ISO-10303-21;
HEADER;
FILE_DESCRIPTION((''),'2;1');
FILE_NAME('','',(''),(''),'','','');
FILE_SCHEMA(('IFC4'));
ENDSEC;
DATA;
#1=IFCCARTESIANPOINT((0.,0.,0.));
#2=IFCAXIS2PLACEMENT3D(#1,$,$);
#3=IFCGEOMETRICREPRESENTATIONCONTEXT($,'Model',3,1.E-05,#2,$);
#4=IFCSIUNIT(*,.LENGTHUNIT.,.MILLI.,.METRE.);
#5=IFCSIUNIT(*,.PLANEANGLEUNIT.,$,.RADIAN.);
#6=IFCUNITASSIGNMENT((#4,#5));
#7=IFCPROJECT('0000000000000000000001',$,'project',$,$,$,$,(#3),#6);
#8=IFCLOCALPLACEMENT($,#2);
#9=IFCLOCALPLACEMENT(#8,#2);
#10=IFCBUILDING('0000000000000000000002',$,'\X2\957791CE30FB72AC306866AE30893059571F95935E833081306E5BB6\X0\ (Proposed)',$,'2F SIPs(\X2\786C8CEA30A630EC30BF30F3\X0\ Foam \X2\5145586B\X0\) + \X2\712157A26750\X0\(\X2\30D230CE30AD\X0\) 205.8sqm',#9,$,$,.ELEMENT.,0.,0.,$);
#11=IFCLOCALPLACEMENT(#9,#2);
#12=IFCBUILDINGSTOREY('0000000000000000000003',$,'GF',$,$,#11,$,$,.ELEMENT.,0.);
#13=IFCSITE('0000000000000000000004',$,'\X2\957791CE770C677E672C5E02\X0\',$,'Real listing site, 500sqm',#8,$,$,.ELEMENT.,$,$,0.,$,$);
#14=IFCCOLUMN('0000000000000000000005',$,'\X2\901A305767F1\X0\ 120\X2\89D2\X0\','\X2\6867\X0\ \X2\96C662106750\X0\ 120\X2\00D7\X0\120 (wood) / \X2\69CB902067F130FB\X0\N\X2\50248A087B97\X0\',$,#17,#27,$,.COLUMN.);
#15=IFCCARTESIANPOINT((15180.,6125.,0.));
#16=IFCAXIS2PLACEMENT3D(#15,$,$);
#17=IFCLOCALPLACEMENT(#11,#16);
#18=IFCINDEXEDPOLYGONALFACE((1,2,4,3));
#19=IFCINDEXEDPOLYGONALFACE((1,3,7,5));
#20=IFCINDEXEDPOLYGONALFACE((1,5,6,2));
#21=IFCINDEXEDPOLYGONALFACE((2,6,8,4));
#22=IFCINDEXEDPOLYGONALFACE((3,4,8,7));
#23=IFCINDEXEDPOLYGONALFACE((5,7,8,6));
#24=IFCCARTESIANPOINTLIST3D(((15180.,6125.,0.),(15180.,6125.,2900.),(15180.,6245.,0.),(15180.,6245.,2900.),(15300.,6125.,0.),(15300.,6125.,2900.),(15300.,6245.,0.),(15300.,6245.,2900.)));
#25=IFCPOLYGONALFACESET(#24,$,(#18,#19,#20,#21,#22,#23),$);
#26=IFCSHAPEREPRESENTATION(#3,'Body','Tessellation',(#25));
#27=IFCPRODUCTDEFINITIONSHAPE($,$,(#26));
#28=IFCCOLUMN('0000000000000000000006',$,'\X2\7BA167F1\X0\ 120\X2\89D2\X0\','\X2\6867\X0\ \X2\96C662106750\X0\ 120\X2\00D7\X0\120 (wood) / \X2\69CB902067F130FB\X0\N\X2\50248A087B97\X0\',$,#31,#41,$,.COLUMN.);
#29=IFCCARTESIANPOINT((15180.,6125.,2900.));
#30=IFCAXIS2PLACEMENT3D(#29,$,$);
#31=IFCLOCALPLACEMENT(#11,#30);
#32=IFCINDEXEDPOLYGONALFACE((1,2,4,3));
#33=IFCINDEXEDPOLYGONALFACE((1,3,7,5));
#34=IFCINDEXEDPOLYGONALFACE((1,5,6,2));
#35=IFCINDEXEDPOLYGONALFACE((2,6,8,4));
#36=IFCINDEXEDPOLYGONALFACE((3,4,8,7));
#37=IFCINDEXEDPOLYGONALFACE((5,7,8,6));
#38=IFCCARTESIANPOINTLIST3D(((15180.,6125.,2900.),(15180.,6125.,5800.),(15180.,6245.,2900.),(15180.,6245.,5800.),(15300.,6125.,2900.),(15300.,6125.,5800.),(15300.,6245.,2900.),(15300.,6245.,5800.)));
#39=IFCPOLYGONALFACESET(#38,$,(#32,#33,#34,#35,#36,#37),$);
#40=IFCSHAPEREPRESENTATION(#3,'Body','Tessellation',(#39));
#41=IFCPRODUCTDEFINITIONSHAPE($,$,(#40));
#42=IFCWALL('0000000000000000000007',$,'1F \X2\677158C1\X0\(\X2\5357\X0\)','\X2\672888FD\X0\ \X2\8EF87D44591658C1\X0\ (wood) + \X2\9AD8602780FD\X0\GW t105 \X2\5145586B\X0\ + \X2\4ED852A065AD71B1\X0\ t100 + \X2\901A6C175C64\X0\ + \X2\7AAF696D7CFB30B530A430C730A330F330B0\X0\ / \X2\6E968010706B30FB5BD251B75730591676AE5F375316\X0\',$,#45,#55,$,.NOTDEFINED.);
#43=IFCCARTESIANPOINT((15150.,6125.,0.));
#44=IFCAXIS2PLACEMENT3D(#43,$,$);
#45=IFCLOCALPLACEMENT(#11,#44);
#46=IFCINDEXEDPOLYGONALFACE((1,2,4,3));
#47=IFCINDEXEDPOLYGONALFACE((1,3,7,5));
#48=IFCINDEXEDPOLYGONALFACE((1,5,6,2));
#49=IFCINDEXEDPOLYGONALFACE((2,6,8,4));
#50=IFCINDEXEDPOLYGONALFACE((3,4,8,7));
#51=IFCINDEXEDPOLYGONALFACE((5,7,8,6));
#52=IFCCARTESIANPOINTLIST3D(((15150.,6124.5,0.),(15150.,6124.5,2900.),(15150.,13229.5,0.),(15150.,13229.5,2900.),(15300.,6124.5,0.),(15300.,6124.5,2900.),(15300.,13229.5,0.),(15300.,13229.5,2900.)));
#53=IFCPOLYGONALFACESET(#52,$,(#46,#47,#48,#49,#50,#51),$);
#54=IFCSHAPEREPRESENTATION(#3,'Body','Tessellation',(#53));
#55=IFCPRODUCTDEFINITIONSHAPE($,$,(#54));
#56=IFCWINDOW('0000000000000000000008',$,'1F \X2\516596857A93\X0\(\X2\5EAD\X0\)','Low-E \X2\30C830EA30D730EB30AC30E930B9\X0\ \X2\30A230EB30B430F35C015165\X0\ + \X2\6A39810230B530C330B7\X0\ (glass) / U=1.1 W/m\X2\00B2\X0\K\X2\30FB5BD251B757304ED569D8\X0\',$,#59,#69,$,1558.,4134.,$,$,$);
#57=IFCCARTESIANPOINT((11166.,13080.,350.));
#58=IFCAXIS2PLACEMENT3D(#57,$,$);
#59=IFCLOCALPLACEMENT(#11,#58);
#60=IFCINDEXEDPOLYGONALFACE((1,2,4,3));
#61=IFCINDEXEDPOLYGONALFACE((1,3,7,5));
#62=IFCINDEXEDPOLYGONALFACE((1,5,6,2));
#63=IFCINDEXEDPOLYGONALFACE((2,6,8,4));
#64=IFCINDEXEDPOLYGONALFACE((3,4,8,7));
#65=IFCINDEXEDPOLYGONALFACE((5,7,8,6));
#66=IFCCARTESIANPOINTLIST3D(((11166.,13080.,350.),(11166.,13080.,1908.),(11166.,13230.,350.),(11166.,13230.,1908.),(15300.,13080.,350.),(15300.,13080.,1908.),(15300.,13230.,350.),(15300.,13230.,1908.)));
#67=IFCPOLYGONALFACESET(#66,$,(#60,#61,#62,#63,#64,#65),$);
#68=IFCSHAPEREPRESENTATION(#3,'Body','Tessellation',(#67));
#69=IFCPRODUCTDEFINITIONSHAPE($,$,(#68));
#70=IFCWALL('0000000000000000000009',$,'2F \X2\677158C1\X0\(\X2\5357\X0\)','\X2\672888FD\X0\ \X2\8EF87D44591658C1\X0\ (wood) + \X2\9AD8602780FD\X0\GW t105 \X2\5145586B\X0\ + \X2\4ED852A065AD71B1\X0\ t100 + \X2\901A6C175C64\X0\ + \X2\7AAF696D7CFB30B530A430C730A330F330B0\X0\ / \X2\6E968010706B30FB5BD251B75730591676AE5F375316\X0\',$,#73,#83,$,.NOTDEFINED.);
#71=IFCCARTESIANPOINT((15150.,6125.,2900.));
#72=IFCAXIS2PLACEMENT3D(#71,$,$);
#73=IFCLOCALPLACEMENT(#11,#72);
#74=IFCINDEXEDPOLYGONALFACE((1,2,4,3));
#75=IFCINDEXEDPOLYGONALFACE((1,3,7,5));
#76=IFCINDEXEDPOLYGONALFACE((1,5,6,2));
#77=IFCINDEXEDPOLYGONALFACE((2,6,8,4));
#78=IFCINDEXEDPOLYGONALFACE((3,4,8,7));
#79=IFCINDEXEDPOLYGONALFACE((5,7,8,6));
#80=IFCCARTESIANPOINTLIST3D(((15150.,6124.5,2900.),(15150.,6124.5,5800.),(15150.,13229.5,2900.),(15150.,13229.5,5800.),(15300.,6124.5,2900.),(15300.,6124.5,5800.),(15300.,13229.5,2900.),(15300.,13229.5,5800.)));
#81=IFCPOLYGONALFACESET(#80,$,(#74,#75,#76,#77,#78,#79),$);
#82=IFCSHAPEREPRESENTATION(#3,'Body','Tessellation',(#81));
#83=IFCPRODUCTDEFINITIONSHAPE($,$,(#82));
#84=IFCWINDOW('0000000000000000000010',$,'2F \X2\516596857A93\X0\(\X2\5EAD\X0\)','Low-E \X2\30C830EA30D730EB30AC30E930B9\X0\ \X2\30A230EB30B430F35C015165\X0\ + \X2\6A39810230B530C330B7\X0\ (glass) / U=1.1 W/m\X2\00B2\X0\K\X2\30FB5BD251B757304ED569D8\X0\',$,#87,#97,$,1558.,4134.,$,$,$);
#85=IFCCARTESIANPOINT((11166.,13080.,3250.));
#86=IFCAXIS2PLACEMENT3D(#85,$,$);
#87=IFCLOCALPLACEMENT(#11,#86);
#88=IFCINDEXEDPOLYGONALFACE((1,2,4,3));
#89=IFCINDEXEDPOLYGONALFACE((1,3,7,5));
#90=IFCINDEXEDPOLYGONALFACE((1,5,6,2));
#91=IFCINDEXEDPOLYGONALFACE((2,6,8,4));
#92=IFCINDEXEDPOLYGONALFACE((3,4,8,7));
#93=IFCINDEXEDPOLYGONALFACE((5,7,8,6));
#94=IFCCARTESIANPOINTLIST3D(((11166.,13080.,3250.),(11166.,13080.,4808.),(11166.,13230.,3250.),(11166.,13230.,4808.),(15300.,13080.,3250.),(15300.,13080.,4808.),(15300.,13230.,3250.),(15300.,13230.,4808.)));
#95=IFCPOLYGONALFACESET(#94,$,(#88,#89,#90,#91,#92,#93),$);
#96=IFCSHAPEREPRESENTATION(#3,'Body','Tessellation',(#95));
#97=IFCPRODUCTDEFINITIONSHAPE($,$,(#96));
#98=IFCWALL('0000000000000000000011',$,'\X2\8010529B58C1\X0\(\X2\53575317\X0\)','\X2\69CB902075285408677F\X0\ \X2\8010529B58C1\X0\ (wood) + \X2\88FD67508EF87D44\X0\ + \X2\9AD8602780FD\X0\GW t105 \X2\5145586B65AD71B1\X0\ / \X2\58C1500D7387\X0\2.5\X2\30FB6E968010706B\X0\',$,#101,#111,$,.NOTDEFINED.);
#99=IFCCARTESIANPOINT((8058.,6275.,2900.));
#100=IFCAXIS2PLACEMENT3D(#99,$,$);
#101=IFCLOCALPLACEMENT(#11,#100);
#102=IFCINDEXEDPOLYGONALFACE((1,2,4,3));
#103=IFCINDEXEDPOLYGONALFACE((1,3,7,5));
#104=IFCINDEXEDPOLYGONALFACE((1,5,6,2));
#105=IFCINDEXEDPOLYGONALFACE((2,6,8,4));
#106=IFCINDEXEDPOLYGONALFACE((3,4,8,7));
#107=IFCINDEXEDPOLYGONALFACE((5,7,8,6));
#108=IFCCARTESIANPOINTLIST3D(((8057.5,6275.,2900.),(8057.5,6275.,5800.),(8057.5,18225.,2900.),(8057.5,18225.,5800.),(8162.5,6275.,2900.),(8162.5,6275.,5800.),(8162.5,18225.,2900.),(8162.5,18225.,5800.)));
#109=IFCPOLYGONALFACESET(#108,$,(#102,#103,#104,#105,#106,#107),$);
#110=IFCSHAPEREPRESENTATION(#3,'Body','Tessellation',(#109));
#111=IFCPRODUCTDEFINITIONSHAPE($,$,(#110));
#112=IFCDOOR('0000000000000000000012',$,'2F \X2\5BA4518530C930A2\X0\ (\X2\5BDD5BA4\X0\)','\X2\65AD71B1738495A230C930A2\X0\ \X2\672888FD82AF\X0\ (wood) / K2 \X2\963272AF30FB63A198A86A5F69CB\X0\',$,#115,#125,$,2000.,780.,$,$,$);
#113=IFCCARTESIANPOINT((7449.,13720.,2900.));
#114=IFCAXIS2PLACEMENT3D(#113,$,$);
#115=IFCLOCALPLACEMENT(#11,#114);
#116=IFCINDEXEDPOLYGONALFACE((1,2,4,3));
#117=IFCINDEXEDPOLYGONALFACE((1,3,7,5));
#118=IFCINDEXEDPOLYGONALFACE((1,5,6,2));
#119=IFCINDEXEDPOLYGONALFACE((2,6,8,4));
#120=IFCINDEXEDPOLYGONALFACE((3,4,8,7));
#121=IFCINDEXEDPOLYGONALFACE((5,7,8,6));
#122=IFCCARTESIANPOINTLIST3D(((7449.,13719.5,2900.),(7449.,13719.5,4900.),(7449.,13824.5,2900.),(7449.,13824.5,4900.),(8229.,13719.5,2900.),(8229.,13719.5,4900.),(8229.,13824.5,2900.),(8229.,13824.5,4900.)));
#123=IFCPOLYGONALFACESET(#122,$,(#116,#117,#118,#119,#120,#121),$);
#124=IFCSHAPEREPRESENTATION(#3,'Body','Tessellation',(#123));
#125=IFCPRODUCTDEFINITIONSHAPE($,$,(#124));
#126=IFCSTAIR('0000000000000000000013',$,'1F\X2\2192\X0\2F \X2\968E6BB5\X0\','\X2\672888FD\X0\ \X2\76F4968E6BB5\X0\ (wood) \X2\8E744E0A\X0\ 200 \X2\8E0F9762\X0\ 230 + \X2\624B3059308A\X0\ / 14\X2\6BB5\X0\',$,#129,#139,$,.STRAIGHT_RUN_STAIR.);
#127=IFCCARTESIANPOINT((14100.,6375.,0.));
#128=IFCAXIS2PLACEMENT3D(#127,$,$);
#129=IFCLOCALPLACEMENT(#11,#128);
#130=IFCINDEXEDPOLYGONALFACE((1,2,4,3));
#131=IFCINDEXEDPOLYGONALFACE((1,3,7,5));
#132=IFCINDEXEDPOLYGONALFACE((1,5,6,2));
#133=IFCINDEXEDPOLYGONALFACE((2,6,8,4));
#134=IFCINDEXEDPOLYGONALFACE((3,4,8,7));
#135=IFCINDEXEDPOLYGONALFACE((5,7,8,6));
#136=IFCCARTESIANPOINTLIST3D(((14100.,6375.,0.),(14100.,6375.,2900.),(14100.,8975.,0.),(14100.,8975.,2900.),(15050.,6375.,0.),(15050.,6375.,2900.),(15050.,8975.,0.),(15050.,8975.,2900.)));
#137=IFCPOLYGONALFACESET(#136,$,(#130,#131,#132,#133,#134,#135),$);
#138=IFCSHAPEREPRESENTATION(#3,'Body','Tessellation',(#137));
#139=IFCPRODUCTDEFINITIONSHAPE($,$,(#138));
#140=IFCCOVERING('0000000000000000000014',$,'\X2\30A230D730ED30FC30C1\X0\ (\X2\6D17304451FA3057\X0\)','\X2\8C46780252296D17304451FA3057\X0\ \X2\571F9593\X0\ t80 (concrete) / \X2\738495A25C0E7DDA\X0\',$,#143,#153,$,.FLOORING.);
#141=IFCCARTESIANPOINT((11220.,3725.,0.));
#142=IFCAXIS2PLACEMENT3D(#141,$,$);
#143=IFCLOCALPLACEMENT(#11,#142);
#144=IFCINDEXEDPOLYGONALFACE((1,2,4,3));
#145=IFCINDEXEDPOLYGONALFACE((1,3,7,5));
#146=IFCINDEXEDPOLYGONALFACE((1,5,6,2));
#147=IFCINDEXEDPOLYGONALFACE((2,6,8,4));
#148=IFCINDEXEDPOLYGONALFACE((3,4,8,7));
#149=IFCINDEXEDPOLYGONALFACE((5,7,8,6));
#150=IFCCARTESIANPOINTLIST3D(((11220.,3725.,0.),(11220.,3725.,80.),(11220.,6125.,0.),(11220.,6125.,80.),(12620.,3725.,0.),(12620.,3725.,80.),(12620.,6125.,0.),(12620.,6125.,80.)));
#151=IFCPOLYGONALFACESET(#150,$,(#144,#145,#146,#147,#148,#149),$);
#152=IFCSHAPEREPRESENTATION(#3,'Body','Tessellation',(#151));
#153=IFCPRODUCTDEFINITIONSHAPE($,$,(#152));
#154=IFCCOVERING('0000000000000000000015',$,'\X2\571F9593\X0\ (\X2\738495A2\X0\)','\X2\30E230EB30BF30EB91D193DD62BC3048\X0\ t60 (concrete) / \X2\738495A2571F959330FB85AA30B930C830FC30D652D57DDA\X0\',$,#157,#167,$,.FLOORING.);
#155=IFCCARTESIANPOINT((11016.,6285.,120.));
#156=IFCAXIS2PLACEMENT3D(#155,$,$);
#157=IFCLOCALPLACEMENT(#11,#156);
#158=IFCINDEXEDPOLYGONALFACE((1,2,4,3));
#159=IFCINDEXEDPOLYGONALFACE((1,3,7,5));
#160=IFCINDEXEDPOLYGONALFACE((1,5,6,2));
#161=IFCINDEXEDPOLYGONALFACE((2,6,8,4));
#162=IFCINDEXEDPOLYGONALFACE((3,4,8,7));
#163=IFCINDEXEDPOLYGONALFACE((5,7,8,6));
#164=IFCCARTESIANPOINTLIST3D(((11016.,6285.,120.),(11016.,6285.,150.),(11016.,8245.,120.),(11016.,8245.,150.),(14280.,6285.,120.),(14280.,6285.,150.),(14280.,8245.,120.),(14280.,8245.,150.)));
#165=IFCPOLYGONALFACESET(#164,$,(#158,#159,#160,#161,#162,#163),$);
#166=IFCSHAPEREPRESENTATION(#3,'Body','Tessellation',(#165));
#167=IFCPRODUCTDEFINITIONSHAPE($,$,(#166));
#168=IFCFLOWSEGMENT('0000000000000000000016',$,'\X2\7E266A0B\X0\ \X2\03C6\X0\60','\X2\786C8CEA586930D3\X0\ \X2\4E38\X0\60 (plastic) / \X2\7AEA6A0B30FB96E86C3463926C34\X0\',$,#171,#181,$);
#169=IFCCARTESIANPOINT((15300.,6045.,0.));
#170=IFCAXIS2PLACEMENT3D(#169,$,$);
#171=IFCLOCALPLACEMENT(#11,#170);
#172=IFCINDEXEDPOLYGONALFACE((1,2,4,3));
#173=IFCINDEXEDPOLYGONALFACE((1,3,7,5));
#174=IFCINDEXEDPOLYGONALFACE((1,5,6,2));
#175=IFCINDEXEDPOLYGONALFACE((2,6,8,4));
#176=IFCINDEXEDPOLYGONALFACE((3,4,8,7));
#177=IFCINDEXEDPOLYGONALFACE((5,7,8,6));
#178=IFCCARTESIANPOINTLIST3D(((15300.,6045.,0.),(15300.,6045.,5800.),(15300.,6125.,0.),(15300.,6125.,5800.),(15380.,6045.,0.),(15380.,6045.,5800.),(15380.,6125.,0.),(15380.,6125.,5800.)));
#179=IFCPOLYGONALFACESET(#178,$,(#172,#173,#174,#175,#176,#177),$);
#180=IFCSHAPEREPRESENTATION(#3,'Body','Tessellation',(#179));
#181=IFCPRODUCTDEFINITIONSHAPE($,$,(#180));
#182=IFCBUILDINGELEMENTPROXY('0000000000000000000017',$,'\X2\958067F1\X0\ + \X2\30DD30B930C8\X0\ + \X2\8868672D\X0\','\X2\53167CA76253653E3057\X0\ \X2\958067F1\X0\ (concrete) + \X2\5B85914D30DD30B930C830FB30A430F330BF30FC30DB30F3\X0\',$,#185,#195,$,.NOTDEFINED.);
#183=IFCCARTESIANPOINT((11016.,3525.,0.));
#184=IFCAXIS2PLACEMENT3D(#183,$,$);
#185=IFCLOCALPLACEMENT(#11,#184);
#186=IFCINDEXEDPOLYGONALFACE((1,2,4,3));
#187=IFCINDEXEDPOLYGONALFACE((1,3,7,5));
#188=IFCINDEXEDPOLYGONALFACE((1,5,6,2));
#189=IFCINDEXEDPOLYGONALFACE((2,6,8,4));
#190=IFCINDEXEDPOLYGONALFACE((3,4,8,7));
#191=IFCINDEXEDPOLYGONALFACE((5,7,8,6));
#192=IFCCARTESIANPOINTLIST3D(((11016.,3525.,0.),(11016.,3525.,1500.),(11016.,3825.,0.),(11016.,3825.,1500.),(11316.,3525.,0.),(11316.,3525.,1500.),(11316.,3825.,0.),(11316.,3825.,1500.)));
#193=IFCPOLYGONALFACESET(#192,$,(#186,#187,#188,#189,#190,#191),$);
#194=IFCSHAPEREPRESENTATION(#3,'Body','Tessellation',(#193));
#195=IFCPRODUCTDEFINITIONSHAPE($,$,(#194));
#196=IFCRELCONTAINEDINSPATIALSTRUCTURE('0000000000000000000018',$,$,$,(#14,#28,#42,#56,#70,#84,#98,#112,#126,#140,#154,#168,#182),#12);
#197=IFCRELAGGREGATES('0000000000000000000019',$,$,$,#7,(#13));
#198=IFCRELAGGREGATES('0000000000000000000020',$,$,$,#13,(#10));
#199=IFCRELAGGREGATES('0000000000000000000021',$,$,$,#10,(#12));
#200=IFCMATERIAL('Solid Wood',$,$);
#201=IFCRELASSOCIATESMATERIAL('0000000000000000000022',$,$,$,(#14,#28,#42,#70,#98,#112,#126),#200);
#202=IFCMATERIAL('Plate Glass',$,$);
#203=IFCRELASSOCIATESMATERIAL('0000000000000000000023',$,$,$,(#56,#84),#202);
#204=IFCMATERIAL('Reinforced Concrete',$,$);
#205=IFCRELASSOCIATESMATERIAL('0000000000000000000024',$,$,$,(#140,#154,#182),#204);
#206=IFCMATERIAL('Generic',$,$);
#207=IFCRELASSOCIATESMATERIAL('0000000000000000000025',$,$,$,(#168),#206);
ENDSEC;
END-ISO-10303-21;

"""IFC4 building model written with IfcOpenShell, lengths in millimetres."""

from ifc_helpers import new_model, si_unit, frame, frame_2d, origin, place, context, project, spatial, rectangle, extrude, material, element, fill, save


model = new_model("IFC4")

# Units and contexts
model_context = context("Model", 3, precision=1e-05, world=origin())
ifc_project = project(units=[si_unit("LENGTHUNIT", "METRE", prefix="MILLI"), si_unit("PLANEANGLEUNIT", "RADIAN")], contexts=[model_context])

# Site, building, storey
site_placement = place(None, origin())
site = spatial("IfcSite", under=ifc_project, at=site_placement, Name="長野県松本市", ObjectType="Real listing site, 500sqm", CompositionType="ELEMENT", RefElevation=0.0)
building_placement = place(site_placement, origin())
building = spatial("IfcBuilding", under=site, at=building_placement, Name="長野・犬と暮らす土間広めの家 (Proposed)", ObjectType="2F SIPs(硬質ウレタン Foam 充填) + 無垢材(ヒノキ) 205.8sqm", CompositionType="ELEMENT", ElevationOfRefHeight=0.0, ElevationOfTerrain=0.0)
storey_placement = place(building_placement, origin())
storey = spatial("IfcBuildingStorey", under=building, at=storey_placement, Name="GF", CompositionType="ELEMENT", Elevation=0.0)

# Columns
ifc_material_1 = material(Name="Solid Wood")
column_1_placement = place(storey_placement, frame((15180.0, 6125.0, 0.0)))
element("IfcColumn", 1, at=column_1_placement, inside=storey, material=ifc_material_1, Name="通し柱 120角", Description="桧 集成材 120×120 (wood) / 構造柱・N値計算", PredefinedType="COLUMN", context=model_context, shape_type="SweptSolid", body=[
    extrude(rectangle(XDim=120.0, YDim=120.0, at=frame_2d((60.0, 60.0))), frame((15180.0, 6125.0, 0.0)), (0.0, 0.0, 1.0), 2900.0),
])
column_2_placement = place(storey_placement, frame((15180.0, 6125.0, 2900.0)))
element("IfcColumn", 2, at=column_2_placement, inside=storey, material=ifc_material_1, Name="管柱 120角", Description="桧 集成材 120×120 (wood) / 構造柱・N値計算", PredefinedType="COLUMN", context=model_context, shape_type="SweptSolid", body=[
    extrude(rectangle(XDim=120.0, YDim=120.0, at=frame_2d((60.0, 60.0))), frame((15180.0, 6125.0, 2900.0)), (0.0, 0.0, 1.0), 2900.0),
])

# Wall, opening, window
wall_1_placement = place(storey_placement, frame((15150.0, 6125.0, 0.0)))
wall_1 = element("IfcWall", 3, at=wall_1_placement, inside=storey, material=ifc_material_1, Name="1F 東壁(南)", Description="木製 軸組外壁 (wood) + 高性能GW t105 充填 + 付加断熱 t100 + 通気層 + 窯業系サイディング / 準耐火・寒冷地外皮強化", PredefinedType="NOTDEFINED", context=model_context, shape_type="SweptSolid", body=[
    extrude(rectangle(XDim=150.0, YDim=7105.0, at=frame_2d((75.0, 3552.0))), frame((15150.0, 6125.0, 0.0)), (0.0, 0.0, 1.0), 2900.0),
])
opening_1_placement = place(storey_placement, frame((11166.0, 13080.0, 350.0)))
opening_1 = element("IfcOpeningElement", 4, at=opening_1_placement, cuts=wall_1, PredefinedType="NOTDEFINED", context=model_context, shape_type="SweptSolid", body=[
    extrude(rectangle(XDim=4134.0, YDim=150.0, at=frame_2d((2067.0, 75.0))), frame((11166.0, 13080.0, 350.0)), (0.0, 0.0, 1.0), 1558.0),
])
ifc_material_2 = material(Name="Plate Glass")
window_1_placement = place(storey_placement, frame((11166.0, 13080.0, 350.0)))
window_1 = element("IfcWindow", 5, at=window_1_placement, inside=storey, material=ifc_material_2, Name="1F 入隅窓(庭)", Description="Low-E トリプルガラス アルゴン封入 + 樹脂サッシ (glass) / U=1.1 W/m²K・寒冷地仕様", OverallHeight=1558.0, OverallWidth=4134.0, context=model_context, shape_type="SweptSolid", body=[
    extrude(rectangle(XDim=4134.0, YDim=150.0, at=frame_2d((2067.0, 75.0))), frame((11166.0, 13080.0, 350.0)), (0.0, 0.0, 1.0), 1558.0),
])
fill(opening_1, window_1)

# Wall, opening, window
wall_2_placement = place(storey_placement, frame((15150.0, 6125.0, 2900.0)))
wall_2 = element("IfcWall", 6, at=wall_2_placement, inside=storey, material=ifc_material_1, Name="2F 東壁(南)", Description="木製 軸組外壁 (wood) + 高性能GW t105 充填 + 付加断熱 t100 + 通気層 + 窯業系サイディング / 準耐火・寒冷地外皮強化", PredefinedType="NOTDEFINED", context=model_context, shape_type="SweptSolid", body=[
    extrude(rectangle(XDim=150.0, YDim=7105.0, at=frame_2d((75.0, 3552.0))), frame((15150.0, 6125.0, 2900.0)), (0.0, 0.0, 1.0), 2900.0),
])
opening_2_placement = place(storey_placement, frame((11166.0, 13080.0, 3250.0)))
opening_2 = element("IfcOpeningElement", 7, at=opening_2_placement, cuts=wall_2, PredefinedType="NOTDEFINED", context=model_context, shape_type="SweptSolid", body=[
    extrude(rectangle(XDim=4134.0, YDim=150.0, at=frame_2d((2067.0, 75.0))), frame((11166.0, 13080.0, 3250.0)), (0.0, 0.0, 1.0), 1558.0),
])
window_2_placement = place(storey_placement, frame((11166.0, 13080.0, 3250.0)))
window_2 = element("IfcWindow", 8, at=window_2_placement, inside=storey, material=ifc_material_2, Name="2F 入隅窓(庭)", Description="Low-E トリプルガラス アルゴン封入 + 樹脂サッシ (glass) / U=1.1 W/m²K・寒冷地仕様", OverallHeight=1558.0, OverallWidth=4134.0, context=model_context, shape_type="SweptSolid", body=[
    extrude(rectangle(XDim=4134.0, YDim=150.0, at=frame_2d((2067.0, 75.0))), frame((11166.0, 13080.0, 3250.0)), (0.0, 0.0, 1.0), 1558.0),
])
fill(opening_2, window_2)

# Wall, opening, door
wall_3_placement = place(storey_placement, frame((8058.0, 6275.0, 2900.0)))
wall_3 = element("IfcWall", 9, at=wall_3_placement, inside=storey, material=ifc_material_1, Name="耐力壁(南北)", Description="構造用合板 耐力壁 (wood) + 製材軸組 + 高性能GW t105 充填断熱 / 壁倍率2.5・準耐火", PredefinedType="NOTDEFINED", context=model_context, shape_type="SweptSolid", body=[
    extrude(rectangle(XDim=105.0, YDim=11950.0, at=frame_2d((52.0, 5975.0))), frame((8058.0, 6275.0, 2900.0)), (0.0, 0.0, 1.0), 2900.0),
])
opening_3_placement = place(storey_placement, frame((7449.0, 13720.0, 2900.0)))
opening_3 = element("IfcOpeningElement", 10, at=opening_3_placement, cuts=wall_3, PredefinedType="NOTDEFINED", context=model_context, shape_type="SweptSolid", body=[
    extrude(rectangle(XDim=780.0, YDim=105.0, at=frame_2d((390.0, 52.0))), frame((7449.0, 13720.0, 2900.0)), (0.0, 0.0, 1.0), 2000.0),
])
door_1_placement = place(storey_placement, frame((7449.0, 13720.0, 2900.0)))
door_1 = element("IfcDoor", 11, at=door_1_placement, inside=storey, material=ifc_material_1, Name="2F 室内ドア (寝室)", Description="断熱玄関ドア 木製芯 (wood) / K2 防犯・採風機構", OverallHeight=2000.0, OverallWidth=780.0, context=model_context, shape_type="SweptSolid", body=[
    extrude(rectangle(XDim=780.0, YDim=105.0, at=frame_2d((390.0, 52.0))), frame((7449.0, 13720.0, 2900.0)), (0.0, 0.0, 1.0), 2000.0),
])
fill(opening_3, door_1)

# Stair
stair_placement = place(storey_placement, frame((14100.0, 6375.0, 0.0)))
element("IfcStair", 12, at=stair_placement, inside=storey, material=ifc_material_1, Name="1F→2F 階段", Description="木製 直階段 (wood) 蹴上 200 踏面 230 + 手すり / 14段", PredefinedType="STRAIGHT_RUN_STAIR", context=model_context, shape_type="SweptSolid", body=[
    extrude(rectangle(XDim=950.0, YDim=2600.0, at=frame_2d((475.0, 1300.0))), frame((14100.0, 6375.0, 0.0)), (0.0, 0.0, 1.0), 2900.0),
])

# Coverings
ifc_material_3 = material(Name="Reinforced Concrete")
covering_1_placement = place(storey_placement, frame((11220.0, 3725.0, 0.0)))
element("IfcCovering", 13, at=covering_1_placement, inside=storey, material=ifc_material_3, Name="アプローチ (洗い出し)", Description="豆砂利洗い出し 土間 t80 (concrete) / 玄関導線", PredefinedType="FLOORING", context=model_context, shape_type="SweptSolid", body=[
    extrude(rectangle(XDim=1400.0, YDim=2400.0, at=frame_2d((700.0, 1200.0))), frame((11220.0, 3725.0, 0.0)), (0.0, 0.0, 1.0), 80.0),
])
covering_2_placement = place(storey_placement, frame((11016.0, 6285.0, 120.0)))
element("IfcCovering", 14, at=covering_2_placement, inside=storey, material=ifc_material_3, Name="土間 (玄関)", Description="モルタル金鏝押え t60 (concrete) / 玄関土間・薪ストーブ動線", PredefinedType="FLOORING", context=model_context, shape_type="SweptSolid", body=[
    extrude(rectangle(XDim=3264.0, YDim=1960.0, at=frame_2d((1632.0, 980.0))), frame((11016.0, 6285.0, 120.0)), (0.0, 0.0, 1.0), 30.0),
])

# Flow segment
ifc_material_4 = material(Name="Generic")
flow_segment_placement = place(storey_placement, frame((15300.0, 6045.0, 0.0)))
element("IfcFlowSegment", 15, at=flow_segment_placement, inside=storey, material=ifc_material_4, Name="縦樋 φ60", Description="硬質塩ビ 丸60 (plastic) / 竪樋・雨水排水", context=model_context, shape_type="SweptSolid", body=[
    extrude(rectangle(XDim=80.0, YDim=80.0, at=frame_2d((40.0, 40.0))), frame((15300.0, 6045.0, 0.0)), (0.0, 0.0, 1.0), 5800.0),
])

# Building element proxy
proxy_placement = place(storey_placement, frame((11016.0, 3525.0, 0.0)))
element("IfcBuildingElementProxy", 16, at=proxy_placement, inside=storey, material=ifc_material_3, Name="門柱 + ポスト + 表札", Description="化粧打放し 門柱 (concrete) + 宅配ポスト・インターホン", PredefinedType="NOTDEFINED", context=model_context, shape_type="SweptSolid", body=[
    extrude(rectangle(XDim=300.0, YDim=300.0, at=frame_2d((150.0, 150.0))), frame((11016.0, 3525.0, 0.0)), (0.0, 0.0, 1.0), 1500.0),
])

save(model, "model.ifc")
